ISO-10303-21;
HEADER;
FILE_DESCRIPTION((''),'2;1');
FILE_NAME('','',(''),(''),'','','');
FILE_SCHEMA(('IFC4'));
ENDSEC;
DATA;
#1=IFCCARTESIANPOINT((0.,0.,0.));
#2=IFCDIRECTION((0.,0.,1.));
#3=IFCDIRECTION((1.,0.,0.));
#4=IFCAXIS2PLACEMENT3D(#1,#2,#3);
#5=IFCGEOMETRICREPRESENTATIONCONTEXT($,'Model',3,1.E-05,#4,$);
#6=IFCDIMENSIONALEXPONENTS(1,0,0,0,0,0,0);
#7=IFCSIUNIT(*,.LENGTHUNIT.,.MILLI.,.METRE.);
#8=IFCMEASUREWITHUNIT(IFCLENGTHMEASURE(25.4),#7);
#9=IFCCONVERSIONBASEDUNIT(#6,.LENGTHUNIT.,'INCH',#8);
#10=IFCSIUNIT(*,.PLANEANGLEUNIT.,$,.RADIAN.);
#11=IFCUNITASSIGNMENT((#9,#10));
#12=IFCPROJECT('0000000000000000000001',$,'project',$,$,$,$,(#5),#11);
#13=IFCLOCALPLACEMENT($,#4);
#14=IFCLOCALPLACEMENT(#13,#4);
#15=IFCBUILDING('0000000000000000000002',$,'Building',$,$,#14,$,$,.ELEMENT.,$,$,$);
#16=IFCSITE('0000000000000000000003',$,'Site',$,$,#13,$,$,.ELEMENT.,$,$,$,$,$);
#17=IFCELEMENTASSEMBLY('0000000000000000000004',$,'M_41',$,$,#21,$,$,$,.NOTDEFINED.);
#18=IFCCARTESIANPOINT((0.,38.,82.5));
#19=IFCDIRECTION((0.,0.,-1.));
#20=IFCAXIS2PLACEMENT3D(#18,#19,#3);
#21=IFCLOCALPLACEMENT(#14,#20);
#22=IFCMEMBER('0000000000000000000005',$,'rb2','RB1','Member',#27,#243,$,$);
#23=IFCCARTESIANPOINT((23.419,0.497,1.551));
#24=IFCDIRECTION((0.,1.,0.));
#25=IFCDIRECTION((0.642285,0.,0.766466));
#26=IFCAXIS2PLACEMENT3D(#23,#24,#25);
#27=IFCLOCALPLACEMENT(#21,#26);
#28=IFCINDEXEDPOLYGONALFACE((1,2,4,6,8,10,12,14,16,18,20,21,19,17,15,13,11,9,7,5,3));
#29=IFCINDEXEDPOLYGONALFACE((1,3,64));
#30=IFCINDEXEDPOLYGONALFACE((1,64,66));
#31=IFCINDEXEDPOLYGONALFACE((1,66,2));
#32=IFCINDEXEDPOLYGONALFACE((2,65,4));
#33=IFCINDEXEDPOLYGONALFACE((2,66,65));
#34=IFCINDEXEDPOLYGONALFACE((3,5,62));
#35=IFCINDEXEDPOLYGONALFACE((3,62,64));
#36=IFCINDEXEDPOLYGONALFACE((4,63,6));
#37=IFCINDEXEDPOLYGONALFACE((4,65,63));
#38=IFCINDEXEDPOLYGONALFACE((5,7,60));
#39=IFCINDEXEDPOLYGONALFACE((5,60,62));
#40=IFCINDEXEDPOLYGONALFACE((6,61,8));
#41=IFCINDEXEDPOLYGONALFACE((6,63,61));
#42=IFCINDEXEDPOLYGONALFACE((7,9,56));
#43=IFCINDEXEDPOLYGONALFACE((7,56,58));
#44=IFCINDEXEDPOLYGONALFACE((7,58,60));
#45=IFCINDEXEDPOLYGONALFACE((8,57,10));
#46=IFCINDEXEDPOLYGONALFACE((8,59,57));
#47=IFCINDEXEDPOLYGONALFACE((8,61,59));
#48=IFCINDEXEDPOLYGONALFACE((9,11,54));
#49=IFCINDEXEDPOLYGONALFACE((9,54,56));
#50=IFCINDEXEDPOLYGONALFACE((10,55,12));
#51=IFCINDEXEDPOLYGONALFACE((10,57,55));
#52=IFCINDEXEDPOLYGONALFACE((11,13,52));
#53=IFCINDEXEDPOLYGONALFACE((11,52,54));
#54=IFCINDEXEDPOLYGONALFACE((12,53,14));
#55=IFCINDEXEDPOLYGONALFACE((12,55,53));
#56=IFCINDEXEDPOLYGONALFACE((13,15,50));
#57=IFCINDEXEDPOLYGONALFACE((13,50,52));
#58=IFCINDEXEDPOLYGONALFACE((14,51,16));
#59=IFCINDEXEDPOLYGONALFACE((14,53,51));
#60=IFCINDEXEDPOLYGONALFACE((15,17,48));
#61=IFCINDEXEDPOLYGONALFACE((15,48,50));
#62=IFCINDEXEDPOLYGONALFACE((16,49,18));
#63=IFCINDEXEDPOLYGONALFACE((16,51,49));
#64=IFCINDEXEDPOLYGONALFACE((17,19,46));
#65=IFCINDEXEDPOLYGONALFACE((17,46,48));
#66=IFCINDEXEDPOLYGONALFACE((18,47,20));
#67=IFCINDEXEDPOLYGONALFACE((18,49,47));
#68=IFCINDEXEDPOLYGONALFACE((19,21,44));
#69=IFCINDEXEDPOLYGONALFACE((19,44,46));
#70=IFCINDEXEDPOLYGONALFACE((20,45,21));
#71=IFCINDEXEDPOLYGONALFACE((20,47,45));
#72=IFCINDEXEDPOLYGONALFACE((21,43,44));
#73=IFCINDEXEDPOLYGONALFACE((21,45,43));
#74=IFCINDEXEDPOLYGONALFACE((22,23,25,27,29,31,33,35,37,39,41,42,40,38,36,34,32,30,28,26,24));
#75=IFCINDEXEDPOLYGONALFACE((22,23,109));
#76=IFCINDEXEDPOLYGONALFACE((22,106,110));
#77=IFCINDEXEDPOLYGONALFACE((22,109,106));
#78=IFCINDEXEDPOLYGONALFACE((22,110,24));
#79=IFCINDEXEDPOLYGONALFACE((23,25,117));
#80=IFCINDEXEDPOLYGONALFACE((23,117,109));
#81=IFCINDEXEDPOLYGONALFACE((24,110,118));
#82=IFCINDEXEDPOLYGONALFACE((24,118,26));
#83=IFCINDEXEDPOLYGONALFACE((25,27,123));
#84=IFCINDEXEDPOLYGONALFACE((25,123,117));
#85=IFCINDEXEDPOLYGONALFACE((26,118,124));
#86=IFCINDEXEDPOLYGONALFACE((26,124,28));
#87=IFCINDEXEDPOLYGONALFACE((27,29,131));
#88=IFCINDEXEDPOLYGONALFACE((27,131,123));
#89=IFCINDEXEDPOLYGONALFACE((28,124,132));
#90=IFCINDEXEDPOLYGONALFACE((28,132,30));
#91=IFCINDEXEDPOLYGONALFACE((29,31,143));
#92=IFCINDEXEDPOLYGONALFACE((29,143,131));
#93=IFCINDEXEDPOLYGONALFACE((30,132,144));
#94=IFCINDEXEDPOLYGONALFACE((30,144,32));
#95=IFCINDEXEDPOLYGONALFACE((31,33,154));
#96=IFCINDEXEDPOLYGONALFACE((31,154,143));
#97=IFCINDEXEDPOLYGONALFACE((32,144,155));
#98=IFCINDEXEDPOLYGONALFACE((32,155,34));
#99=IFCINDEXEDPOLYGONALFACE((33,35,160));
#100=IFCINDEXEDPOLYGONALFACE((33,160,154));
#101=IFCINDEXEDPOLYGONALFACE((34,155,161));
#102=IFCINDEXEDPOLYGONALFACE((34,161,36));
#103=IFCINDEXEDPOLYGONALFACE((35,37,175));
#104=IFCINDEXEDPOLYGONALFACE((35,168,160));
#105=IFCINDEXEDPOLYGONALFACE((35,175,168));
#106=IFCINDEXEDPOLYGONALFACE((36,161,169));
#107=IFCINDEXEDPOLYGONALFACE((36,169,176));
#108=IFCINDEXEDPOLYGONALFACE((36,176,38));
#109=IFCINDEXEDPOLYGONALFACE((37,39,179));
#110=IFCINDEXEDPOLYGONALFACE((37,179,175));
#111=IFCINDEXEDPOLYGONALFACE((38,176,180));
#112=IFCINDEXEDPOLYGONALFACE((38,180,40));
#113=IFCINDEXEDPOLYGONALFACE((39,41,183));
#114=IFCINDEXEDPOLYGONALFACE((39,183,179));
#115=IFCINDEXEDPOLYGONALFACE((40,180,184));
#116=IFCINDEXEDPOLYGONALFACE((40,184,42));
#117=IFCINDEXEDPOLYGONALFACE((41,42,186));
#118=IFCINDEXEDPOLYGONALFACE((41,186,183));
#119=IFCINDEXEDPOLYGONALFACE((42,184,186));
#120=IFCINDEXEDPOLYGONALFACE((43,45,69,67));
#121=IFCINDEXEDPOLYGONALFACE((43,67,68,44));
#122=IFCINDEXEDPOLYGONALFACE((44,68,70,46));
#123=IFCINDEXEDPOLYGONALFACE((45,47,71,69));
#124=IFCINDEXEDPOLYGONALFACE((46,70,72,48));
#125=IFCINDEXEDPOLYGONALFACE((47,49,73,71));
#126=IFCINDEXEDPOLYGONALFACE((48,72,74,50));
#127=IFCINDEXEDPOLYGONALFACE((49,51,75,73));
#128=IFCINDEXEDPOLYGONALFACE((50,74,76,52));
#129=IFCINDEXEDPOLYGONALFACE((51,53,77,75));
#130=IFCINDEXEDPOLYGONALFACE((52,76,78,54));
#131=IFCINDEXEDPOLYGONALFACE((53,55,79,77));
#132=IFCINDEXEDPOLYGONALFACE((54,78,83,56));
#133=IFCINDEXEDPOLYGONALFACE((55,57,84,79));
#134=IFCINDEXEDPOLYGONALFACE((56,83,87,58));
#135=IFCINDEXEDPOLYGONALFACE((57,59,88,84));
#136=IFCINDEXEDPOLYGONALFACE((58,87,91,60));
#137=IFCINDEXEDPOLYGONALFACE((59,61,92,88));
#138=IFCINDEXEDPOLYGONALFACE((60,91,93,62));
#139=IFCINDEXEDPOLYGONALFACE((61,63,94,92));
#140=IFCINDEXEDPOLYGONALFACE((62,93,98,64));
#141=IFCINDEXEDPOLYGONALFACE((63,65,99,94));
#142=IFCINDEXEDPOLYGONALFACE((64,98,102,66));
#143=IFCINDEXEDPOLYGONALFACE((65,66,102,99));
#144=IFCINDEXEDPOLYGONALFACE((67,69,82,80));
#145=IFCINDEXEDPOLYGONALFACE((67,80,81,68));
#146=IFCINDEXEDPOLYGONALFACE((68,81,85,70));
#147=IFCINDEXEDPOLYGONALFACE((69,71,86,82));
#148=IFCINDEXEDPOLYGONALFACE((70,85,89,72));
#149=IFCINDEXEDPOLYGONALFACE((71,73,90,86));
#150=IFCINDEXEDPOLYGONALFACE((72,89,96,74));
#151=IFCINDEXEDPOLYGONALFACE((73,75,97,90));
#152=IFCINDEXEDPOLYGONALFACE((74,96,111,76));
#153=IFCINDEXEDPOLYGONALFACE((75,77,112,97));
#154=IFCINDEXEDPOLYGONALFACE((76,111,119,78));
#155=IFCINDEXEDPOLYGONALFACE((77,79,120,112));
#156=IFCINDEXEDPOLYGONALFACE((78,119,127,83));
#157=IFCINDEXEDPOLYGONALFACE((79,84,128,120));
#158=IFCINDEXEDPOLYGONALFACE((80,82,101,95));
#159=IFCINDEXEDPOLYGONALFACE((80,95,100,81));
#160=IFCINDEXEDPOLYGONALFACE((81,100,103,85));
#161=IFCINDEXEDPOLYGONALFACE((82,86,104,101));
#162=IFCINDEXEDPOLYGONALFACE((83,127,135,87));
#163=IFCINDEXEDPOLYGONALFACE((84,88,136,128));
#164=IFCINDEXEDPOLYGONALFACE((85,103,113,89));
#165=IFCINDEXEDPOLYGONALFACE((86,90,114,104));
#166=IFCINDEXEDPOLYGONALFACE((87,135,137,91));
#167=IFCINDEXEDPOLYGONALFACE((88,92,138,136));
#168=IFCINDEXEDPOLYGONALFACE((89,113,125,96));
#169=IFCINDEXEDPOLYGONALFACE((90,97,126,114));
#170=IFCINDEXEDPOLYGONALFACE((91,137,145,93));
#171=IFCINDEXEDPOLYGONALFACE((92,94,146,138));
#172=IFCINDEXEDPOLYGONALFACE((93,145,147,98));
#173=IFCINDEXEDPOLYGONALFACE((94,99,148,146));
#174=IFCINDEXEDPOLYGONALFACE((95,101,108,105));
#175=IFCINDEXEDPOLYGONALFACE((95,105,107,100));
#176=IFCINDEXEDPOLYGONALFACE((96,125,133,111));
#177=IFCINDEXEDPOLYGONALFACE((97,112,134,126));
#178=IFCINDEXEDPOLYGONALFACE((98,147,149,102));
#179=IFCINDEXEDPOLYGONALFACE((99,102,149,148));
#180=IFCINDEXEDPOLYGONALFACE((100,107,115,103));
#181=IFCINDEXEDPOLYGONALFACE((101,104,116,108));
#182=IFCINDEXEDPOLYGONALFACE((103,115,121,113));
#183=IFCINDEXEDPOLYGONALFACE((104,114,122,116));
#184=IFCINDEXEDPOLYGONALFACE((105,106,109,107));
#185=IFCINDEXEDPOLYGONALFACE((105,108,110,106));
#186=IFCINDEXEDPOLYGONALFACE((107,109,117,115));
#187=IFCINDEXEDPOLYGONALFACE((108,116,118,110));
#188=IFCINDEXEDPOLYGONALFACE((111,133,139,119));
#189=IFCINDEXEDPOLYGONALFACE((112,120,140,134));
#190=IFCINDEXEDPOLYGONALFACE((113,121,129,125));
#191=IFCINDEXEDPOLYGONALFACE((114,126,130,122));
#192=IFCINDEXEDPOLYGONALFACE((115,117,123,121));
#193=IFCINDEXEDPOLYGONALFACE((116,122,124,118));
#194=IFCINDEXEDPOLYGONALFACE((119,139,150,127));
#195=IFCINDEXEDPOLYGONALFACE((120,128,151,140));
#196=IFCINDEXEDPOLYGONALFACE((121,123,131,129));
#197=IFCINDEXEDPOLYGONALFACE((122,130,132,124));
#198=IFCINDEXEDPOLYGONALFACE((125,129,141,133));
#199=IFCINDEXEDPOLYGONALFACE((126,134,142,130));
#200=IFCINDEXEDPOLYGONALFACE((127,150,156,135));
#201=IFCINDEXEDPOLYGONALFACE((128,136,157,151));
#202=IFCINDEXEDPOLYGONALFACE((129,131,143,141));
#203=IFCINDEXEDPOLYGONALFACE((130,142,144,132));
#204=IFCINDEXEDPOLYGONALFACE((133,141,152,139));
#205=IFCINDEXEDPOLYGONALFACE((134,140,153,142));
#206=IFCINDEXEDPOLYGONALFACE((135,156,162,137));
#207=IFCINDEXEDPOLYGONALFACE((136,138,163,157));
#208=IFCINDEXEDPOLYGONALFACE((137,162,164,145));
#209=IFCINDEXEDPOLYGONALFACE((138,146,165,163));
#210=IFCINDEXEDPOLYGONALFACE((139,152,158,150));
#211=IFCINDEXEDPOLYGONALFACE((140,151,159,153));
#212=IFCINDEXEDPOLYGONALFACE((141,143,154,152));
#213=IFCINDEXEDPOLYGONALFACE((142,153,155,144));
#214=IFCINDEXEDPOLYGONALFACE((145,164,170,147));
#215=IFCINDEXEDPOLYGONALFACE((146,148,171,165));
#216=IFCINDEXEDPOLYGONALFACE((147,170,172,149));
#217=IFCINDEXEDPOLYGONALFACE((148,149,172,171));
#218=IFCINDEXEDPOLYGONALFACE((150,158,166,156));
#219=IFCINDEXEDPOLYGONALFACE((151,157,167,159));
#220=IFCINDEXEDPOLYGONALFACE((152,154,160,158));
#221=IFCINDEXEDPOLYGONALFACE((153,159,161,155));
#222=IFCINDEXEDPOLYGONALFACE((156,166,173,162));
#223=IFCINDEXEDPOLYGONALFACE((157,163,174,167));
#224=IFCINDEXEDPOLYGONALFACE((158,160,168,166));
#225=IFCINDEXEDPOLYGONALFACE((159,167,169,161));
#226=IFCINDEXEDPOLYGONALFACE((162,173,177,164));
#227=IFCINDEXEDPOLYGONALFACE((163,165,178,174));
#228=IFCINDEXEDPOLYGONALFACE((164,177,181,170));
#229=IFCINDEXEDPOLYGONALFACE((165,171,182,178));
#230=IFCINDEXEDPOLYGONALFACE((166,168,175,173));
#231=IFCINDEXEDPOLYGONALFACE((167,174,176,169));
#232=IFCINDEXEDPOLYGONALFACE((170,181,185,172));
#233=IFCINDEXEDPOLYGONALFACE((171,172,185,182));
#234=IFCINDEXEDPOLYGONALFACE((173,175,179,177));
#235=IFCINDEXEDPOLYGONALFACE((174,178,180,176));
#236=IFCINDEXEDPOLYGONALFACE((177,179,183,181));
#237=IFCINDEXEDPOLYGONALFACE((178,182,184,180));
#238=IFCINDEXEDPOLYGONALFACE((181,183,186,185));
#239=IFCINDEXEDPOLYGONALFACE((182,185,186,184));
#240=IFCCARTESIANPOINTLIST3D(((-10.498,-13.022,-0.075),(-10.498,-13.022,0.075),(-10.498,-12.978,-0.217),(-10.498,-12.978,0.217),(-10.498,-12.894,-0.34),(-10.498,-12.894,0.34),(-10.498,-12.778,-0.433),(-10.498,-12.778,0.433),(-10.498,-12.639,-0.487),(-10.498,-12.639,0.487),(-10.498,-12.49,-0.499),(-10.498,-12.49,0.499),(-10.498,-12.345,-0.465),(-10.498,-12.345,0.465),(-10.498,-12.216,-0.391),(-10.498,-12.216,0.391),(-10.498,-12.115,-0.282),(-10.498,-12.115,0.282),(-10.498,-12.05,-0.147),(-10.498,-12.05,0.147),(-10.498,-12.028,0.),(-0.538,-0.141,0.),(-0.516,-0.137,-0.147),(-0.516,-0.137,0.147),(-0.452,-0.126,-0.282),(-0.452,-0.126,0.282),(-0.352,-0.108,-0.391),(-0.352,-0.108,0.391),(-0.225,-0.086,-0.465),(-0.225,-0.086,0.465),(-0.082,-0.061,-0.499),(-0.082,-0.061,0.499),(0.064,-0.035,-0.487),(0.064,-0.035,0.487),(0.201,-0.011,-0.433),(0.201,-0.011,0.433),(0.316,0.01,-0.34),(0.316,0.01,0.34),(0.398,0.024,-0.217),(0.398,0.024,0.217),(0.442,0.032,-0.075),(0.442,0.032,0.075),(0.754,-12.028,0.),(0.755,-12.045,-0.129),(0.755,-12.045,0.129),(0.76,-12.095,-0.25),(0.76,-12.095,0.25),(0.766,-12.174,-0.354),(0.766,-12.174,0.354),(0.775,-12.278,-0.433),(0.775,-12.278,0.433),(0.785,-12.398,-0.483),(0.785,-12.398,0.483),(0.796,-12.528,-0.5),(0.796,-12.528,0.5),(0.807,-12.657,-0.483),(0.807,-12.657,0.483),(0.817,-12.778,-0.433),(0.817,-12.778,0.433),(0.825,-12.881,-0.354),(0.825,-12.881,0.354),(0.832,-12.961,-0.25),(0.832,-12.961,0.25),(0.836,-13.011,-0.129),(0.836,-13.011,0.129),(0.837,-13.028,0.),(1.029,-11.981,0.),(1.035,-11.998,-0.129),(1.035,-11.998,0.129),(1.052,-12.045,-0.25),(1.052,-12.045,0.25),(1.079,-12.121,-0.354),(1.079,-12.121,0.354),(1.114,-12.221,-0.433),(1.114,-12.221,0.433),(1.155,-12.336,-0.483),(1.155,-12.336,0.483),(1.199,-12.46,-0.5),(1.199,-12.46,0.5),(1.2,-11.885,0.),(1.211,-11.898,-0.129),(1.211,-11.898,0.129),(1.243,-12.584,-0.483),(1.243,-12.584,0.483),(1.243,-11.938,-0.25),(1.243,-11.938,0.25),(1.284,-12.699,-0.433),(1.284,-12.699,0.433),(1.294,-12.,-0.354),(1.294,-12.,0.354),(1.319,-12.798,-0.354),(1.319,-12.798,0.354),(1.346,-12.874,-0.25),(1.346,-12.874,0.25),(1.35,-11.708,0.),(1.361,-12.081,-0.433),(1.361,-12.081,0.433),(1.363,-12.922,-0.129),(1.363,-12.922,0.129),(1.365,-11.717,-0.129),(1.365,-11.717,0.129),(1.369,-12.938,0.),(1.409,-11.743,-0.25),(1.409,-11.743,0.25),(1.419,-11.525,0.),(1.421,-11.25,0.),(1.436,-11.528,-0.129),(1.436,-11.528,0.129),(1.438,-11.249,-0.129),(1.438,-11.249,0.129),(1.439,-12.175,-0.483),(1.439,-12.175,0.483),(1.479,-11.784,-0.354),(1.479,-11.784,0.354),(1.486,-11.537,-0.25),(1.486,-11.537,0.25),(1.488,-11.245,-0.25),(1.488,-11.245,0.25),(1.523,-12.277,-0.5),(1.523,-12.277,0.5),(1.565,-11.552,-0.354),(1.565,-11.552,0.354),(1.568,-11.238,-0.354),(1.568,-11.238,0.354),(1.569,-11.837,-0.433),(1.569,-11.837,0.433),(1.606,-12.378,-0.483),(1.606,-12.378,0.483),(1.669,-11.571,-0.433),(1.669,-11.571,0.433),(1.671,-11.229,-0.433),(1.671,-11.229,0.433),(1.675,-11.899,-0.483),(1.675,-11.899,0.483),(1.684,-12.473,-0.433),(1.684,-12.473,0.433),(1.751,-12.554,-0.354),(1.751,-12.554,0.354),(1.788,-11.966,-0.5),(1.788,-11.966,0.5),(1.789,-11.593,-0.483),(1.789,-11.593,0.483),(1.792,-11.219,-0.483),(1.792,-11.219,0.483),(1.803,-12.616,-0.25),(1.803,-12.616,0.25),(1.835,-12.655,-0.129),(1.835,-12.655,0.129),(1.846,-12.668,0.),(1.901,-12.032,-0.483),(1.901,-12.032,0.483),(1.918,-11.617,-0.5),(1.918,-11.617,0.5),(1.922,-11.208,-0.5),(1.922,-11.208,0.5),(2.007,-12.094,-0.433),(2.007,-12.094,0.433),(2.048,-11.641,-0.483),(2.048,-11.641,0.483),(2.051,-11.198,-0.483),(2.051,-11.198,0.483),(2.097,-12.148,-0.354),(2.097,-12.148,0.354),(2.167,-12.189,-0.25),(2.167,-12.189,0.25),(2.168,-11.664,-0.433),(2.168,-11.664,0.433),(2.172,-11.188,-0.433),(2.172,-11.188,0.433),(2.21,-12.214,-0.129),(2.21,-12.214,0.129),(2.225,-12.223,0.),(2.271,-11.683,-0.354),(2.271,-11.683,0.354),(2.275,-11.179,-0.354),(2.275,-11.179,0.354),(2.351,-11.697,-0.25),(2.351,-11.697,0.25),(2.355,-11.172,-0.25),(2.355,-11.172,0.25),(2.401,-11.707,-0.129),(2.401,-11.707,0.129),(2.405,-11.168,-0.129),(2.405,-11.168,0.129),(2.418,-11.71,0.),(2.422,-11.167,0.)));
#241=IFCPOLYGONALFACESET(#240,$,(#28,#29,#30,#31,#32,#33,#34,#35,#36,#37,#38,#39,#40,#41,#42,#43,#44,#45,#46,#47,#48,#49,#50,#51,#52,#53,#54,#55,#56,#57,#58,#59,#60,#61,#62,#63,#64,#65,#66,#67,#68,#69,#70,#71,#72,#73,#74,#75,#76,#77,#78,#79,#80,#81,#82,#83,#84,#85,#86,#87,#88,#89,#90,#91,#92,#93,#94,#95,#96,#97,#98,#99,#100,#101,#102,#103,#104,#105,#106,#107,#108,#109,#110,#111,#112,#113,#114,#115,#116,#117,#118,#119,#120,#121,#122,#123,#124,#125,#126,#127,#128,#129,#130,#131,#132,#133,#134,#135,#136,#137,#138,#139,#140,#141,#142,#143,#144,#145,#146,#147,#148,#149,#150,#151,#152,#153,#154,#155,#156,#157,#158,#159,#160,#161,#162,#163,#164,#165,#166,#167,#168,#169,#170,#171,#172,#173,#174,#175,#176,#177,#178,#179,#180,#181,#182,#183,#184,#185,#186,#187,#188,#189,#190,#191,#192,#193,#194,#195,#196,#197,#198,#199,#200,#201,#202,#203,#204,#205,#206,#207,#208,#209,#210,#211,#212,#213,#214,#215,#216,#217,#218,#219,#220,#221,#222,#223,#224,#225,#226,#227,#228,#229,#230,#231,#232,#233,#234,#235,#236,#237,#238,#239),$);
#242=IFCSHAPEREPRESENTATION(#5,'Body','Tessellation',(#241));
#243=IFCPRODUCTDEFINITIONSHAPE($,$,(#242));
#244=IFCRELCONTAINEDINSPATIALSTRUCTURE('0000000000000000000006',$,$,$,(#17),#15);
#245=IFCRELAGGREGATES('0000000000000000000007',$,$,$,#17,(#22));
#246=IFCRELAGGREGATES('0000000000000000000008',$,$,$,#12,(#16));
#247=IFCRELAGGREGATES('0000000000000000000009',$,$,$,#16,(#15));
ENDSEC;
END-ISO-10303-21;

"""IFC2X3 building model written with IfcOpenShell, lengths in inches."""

from ifc_helpers import new_model, entity, si_unit, converted_unit, frame, origin_with_axes, place, context, project, spatial, element, aggregate, save


model = new_model("IFC2X3")

# Units and contexts
model_context = context("Model", 3, precision=1e-05, world=origin_with_axes())
ifc_project = project(units=[converted_unit("LENGTHUNIT", "INCH", entity("IfcLengthMeasure", 25.4), si_unit("LENGTHUNIT", "METRE", prefix="MILLI"), dimensions=[1, 0, 0, 0, 0, 0, 0]), si_unit("PLANEANGLEUNIT", "RADIAN")], contexts=[model_context])

# Site, building
site_placement = place(None, origin_with_axes())
site = spatial("IfcSite", under=ifc_project, at=site_placement, Name="Site", CompositionType="ELEMENT")
building_placement = place(site_placement, origin_with_axes())
building = spatial("IfcBuilding", under=site, at=building_placement, Name="Building", CompositionType="ELEMENT")

# Element assembly, member
assembly_1_placement = place(building_placement, frame((0.0, 38.0, 82.5), z_axis=(0.0, 0.0, -1.0), x_axis=(1.0, 0.0, 0.0)))
assembly_1 = element("IfcElementAssembly", 1, at=assembly_1_placement, inside=building, Name="M_41", PredefinedType="NOTDEFINED")
member_1_placement = place(assembly_1_placement, frame((23.419, 0.497, 1.551), z_axis=(0.0, 1.0, 0.0), x_axis=(0.642285, 0.0, 0.766466)))
cartesian_point_1 = entity("IfcCartesianPoint", [0.0, 0.0, 0.0])
ifc_direction_1 = entity("IfcDirection", [0.0, 0.0, 1.0])
member_1 = element("IfcMember", 2, at=member_1_placement, Name="rb2", Description="RB1", ObjectType="Member", context=model_context, shape_type="SweptSolid", body=[
    entity("IfcSurfaceCurveSweptAreaSolid", entity("IfcCircleProfileDef", "AREA", None, entity("IfcAxis2Placement2D", entity("IfcCartesianPoint", [0.0, 0.0]), entity("IfcDirection", [1.0, 0.0])), 0.5), entity("IfcAxis2Placement3D", cartesian_point_1, ifc_direction_1, entity("IfcDirection", [1.0, 0.0, 0.0])), entity("IfcPolyline", [entity("IfcCartesianPoint", [-0.045, -0.054]), entity("IfcCartesianPoint", [1.921, -11.208]), entity("IfcCartesianPoint", [1.918, -11.617]), entity("IfcCartesianPoint", [1.788, -11.966]), entity("IfcCartesianPoint", [1.523, -12.277]), entity("IfcCartesianPoint", [1.199, -12.46]), entity("IfcCartesianPoint", [0.796, -12.528]), entity("IfcCartesianPoint", [-10.498, -12.528])]), 0.0, 1.0, entity("IfcPlane", entity("IfcAxis2Placement3D", cartesian_point_1, entity("IfcDirection", [0.0, 1.0, 0.0]), ifc_direction_1))),
])
aggregate(assembly_1, [member_1])

save(model, "model.ifc")
